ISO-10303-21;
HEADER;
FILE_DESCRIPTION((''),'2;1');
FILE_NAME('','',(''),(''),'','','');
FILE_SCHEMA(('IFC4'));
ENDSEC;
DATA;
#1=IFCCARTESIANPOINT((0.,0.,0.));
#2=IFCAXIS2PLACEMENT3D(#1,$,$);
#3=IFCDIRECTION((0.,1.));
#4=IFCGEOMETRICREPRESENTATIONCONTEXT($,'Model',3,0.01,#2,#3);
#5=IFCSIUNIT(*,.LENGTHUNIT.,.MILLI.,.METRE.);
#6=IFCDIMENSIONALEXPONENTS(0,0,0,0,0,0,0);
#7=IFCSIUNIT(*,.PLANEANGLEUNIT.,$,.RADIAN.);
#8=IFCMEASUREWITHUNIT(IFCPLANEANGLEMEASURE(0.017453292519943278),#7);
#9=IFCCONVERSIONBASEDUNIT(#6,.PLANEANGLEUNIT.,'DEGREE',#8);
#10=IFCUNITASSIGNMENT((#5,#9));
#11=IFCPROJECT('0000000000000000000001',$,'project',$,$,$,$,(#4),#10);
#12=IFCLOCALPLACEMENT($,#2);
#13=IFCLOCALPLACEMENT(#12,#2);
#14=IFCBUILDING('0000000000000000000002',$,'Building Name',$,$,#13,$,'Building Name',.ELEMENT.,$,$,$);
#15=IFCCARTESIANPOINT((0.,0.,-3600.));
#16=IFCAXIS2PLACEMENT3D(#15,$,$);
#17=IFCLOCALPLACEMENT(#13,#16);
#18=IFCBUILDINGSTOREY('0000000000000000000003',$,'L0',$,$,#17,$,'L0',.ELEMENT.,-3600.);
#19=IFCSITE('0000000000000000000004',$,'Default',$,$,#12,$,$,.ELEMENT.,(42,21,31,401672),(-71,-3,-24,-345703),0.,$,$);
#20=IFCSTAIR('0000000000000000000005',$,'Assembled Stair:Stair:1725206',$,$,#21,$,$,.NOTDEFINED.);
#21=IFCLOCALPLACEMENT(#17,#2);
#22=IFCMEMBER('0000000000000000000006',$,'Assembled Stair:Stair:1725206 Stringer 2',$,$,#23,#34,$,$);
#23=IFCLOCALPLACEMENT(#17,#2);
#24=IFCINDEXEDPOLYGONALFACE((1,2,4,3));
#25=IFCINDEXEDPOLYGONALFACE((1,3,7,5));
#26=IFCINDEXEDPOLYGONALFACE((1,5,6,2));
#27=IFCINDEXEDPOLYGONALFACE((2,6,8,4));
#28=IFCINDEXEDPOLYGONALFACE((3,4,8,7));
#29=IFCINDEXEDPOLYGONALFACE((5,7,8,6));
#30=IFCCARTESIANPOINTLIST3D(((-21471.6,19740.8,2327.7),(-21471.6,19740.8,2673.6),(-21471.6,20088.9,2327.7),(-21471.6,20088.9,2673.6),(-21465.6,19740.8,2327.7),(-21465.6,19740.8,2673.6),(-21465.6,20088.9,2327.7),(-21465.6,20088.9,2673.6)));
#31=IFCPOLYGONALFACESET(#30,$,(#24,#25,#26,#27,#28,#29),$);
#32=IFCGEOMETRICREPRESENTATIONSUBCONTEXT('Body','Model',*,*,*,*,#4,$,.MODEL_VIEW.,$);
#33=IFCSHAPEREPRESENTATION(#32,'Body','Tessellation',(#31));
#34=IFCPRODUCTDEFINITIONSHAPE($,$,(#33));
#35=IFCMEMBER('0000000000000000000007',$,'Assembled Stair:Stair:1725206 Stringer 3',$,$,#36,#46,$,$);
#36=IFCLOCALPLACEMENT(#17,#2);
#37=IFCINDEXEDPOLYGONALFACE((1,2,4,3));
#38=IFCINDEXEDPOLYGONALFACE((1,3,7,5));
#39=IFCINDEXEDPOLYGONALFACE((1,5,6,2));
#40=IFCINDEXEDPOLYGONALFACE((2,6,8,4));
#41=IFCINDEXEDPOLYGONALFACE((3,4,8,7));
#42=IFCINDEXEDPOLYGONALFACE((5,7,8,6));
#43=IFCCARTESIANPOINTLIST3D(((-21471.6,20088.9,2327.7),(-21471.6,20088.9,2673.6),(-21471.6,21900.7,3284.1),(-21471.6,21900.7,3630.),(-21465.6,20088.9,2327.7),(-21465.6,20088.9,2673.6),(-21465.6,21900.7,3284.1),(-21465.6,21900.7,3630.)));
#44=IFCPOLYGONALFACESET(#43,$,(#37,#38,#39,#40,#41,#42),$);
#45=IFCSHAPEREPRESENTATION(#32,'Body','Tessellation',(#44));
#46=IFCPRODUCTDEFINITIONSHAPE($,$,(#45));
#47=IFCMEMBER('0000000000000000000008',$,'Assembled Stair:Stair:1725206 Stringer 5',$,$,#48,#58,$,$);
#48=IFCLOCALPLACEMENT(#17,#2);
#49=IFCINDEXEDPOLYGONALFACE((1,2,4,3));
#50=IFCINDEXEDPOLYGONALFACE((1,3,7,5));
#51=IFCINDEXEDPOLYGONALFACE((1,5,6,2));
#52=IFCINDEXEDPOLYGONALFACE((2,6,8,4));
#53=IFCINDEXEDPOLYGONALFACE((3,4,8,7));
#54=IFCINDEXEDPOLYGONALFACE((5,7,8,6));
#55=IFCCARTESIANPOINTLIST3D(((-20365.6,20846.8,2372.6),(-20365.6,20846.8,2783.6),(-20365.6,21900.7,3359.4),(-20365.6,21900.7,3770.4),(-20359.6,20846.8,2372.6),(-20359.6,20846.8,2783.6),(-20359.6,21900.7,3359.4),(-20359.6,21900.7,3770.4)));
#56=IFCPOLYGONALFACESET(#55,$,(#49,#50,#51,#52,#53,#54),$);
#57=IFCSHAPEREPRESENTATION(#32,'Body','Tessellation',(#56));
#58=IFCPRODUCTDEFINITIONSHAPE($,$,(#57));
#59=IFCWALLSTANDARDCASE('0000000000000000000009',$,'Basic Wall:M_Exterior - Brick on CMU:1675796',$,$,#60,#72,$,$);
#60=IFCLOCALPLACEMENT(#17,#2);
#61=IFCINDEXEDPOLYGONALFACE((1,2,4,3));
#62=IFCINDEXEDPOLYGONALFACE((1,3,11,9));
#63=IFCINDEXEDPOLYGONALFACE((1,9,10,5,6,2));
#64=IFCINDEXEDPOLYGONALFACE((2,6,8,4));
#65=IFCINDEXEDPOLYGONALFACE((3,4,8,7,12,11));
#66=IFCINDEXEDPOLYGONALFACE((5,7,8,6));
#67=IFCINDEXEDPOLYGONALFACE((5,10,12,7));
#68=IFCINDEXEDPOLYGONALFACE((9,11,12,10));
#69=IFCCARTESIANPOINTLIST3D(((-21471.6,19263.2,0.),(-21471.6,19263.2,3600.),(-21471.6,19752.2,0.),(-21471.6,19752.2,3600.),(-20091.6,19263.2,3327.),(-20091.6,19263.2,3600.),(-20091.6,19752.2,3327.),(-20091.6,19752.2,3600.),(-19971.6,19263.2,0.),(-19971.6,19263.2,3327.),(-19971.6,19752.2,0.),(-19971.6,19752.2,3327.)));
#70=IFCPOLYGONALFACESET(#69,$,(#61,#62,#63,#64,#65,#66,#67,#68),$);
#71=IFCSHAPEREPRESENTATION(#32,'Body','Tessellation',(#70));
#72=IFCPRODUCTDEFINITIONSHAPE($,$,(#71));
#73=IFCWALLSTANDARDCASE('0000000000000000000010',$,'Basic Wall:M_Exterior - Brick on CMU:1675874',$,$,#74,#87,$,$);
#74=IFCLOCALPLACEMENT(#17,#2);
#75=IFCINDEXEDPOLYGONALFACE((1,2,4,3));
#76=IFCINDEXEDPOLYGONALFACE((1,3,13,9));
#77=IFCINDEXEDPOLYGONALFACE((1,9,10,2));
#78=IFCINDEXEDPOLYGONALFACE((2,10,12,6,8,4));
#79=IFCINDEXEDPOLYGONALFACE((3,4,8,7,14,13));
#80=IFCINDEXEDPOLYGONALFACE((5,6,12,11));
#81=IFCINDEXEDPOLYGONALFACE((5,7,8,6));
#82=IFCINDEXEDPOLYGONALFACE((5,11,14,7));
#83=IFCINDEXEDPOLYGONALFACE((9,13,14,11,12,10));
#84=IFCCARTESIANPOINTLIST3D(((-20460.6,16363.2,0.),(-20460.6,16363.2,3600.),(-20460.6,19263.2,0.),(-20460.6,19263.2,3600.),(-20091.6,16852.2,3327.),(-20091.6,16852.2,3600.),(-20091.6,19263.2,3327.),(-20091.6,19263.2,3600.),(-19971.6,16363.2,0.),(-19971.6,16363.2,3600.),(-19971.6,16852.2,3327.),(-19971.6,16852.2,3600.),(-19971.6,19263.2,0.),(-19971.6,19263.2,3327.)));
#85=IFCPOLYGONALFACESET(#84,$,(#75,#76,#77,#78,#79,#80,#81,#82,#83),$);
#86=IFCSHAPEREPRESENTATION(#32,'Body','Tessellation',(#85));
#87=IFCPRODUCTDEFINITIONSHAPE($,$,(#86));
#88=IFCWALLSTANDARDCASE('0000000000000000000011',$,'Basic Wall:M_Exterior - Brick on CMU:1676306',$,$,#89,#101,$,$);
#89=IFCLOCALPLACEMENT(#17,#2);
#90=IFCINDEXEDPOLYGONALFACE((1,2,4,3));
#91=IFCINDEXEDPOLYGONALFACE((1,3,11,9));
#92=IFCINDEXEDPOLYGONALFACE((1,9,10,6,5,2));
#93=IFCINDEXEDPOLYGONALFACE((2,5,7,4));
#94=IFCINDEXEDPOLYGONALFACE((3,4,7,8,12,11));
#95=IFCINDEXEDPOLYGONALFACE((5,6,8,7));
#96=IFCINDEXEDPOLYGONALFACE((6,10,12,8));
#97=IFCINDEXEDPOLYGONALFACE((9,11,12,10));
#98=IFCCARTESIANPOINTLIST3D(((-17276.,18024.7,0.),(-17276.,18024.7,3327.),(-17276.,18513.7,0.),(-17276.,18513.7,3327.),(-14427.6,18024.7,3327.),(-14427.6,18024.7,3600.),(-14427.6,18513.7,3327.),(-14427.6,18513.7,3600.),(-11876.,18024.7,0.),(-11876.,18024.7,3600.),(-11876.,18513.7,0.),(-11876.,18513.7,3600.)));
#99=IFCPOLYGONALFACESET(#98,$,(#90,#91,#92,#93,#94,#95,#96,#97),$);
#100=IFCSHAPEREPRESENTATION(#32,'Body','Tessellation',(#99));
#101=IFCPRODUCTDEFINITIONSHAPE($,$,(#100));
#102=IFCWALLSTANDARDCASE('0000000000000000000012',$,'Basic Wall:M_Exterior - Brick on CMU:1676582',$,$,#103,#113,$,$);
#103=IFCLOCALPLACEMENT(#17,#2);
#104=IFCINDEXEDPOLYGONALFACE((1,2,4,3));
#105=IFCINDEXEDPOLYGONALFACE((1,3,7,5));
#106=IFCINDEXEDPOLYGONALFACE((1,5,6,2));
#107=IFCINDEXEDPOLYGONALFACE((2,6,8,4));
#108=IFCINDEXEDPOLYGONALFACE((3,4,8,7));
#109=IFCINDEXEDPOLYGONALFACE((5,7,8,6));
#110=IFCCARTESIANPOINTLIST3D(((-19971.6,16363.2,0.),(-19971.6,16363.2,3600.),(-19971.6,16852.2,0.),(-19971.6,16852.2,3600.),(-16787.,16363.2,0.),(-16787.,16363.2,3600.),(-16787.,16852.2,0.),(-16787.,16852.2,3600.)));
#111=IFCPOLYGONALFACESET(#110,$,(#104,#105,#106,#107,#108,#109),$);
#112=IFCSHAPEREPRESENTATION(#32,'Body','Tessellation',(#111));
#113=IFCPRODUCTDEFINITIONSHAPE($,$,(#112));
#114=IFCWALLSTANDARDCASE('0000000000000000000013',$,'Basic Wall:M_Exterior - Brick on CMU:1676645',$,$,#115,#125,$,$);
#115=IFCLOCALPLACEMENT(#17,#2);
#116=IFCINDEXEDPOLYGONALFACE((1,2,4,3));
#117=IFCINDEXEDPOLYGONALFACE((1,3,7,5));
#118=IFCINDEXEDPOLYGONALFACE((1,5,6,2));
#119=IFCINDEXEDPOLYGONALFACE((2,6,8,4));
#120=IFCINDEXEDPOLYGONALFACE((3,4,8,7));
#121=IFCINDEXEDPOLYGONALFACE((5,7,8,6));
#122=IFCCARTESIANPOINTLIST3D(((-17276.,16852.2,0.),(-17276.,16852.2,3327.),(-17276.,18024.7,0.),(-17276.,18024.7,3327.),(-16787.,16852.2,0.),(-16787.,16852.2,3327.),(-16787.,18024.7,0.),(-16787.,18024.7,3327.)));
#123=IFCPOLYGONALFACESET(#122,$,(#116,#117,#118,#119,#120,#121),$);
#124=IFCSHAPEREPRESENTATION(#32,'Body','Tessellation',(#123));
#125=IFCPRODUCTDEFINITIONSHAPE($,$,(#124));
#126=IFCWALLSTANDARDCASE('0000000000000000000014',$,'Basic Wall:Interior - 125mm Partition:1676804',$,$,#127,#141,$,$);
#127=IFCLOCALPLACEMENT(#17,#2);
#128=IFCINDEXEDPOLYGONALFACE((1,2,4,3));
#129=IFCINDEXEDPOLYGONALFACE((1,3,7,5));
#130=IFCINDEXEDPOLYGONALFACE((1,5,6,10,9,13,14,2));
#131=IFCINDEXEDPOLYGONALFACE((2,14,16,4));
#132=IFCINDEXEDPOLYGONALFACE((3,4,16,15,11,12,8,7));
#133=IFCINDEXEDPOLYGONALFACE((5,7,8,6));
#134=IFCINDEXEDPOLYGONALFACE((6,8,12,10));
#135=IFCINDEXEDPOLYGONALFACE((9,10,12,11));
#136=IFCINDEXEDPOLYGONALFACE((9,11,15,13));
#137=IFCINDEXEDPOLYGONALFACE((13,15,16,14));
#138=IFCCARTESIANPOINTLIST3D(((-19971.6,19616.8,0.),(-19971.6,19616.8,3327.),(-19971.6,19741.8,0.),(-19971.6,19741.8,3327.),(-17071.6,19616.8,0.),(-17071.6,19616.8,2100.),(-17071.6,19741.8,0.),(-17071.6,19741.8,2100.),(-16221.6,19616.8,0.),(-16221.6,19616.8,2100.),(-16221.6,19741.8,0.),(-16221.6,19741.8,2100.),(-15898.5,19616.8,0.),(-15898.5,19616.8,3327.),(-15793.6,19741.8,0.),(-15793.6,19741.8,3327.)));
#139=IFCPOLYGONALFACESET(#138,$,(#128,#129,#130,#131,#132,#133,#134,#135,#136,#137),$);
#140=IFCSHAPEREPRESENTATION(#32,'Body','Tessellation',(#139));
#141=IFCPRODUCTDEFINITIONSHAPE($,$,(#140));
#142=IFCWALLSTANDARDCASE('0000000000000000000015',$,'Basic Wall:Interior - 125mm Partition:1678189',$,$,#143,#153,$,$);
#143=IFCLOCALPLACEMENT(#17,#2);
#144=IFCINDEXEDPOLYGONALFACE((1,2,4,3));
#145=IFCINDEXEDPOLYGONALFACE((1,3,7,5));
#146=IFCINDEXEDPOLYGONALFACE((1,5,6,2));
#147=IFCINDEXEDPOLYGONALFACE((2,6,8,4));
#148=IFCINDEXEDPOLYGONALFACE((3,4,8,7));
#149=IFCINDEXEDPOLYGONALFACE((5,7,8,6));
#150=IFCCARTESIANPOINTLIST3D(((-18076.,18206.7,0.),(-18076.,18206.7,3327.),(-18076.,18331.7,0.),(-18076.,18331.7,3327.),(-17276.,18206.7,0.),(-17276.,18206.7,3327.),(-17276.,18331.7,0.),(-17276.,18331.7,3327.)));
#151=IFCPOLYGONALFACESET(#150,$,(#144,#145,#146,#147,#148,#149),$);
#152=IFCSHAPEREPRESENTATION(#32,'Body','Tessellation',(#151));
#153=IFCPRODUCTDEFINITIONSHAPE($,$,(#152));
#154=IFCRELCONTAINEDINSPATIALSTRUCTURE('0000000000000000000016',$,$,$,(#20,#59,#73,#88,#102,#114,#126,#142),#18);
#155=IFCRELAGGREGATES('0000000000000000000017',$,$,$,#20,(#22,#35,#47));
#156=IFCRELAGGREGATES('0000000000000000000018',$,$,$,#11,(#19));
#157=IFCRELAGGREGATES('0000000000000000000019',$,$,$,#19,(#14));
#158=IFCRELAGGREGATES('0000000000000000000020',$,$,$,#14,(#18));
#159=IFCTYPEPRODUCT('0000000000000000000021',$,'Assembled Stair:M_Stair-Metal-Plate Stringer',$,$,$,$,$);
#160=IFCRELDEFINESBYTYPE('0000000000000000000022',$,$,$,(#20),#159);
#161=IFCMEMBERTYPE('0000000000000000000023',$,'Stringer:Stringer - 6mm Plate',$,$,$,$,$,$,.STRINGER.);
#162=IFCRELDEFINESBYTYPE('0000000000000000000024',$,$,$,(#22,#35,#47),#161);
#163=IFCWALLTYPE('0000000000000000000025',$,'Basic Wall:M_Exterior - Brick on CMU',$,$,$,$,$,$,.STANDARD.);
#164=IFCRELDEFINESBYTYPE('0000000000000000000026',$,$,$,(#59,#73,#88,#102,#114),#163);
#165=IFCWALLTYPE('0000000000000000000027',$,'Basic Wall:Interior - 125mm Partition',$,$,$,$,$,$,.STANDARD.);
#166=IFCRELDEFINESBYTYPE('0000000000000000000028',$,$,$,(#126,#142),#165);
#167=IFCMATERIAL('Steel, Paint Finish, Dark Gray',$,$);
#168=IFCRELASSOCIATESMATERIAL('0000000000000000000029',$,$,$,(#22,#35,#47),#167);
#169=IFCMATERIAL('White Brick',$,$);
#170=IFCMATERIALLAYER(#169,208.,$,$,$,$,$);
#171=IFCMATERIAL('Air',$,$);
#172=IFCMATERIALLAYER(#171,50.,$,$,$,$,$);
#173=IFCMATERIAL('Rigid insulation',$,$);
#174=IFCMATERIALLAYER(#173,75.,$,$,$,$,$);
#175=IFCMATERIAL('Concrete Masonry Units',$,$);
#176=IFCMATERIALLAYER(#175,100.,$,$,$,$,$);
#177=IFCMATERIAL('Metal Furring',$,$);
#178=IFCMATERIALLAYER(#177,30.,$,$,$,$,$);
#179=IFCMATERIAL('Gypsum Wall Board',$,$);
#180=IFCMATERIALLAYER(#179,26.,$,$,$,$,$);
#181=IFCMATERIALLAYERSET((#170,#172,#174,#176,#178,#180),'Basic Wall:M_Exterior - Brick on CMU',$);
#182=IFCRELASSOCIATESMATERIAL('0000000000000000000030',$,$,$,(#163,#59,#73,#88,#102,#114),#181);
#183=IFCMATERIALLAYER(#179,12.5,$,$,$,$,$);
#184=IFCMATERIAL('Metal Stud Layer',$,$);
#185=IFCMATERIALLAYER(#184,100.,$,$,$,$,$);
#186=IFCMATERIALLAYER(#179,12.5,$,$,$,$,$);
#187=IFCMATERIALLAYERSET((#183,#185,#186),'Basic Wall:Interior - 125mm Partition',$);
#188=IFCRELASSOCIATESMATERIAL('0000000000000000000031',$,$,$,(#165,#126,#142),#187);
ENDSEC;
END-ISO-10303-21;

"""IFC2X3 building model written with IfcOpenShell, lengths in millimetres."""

from ifc_helpers import new_model, entity, si_unit, converted_unit, direction, frame, frame_2d, origin, place, context, subcontext, project, spatial, polyline, rectangle, outline, extrude, clip, bounded_halfspace, material, layer, layer_set, layer_usage, type_object, element, aggregate, save


model = new_model("IFC2X3")

# Units and contexts
model_context = context("Model", 3, precision=0.01, world=origin(), true_north=direction((0.0, 1.0)))
body_context = subcontext(model_context, "Body", "Model", "MODEL_VIEW")
ifc_project = project(units=[si_unit("LENGTHUNIT", "METRE", prefix="MILLI"), converted_unit("PLANEANGLEUNIT", "DEGREE", entity("IfcPlaneAngleMeasure", 0.017453292519943278), si_unit("PLANEANGLEUNIT", "RADIAN"), dimensions=[0, 0, 0, 0, 0, 0, 0])], contexts=[model_context])

# Site, building, storey
site_placement = place(None, origin())
site = spatial("IfcSite", under=ifc_project, at=site_placement, Name="Default", CompositionType="ELEMENT", RefLatitude=(42, 21, 31, 401672), RefLongitude=(-71, -3, -24, -345703), RefElevation=0.0)
building_placement = place(site_placement, origin())
building = spatial("IfcBuilding", under=site, at=building_placement, Name="Building Name", LongName="Building Name", CompositionType="ELEMENT")
storey_placement = place(building_placement, frame((0.0, 0.0, -3600.0)))
storey = spatial("IfcBuildingStorey", under=building, at=storey_placement, Name="L0", LongName="L0", CompositionType="ELEMENT", Elevation=-3600.0)

# Stair, members
type_product = type_object("IfcTypeProduct", Name="Assembled Stair:M_Stair-Metal-Plate Stringer")
stair_placement = place(storey_placement, origin())
stair = element("IfcStair", 1, at=stair_placement, inside=storey, type_object=type_product, Name="Assembled Stair:Stair:1725206", ShapeType="NOTDEFINED")
ifc_material_1 = material(Name="Steel, Paint Finish, Dark Gray")
member_type = type_object("IfcMemberType", Name="Stringer:Stringer - 6mm Plate", PredefinedType="STRINGER")
member_1_placement = place(stair_placement, origin())
member_1 = element("IfcMember", 2, at=member_1_placement, type_object=member_type, material=ifc_material_1, Name="Assembled Stair:Stair:1725206 Stringer 2", context=body_context, shape_type="SweptSolid", body=[
    extrude(rectangle(XDim=348.1, YDim=6.0, at=frame_2d((0.0, 0.0), x_axis=(1.0, 0.0))), frame((-21468.6, 19914.8, 2327.7), z_axis=(0.0, 0.0, 1.0), x_axis=(0.0, 1.0, 0.0)), (0.0, 0.0, 1.0), 345.9),
])
member_2_placement = place(stair_placement, origin())
member_2 = element("IfcMember", 3, at=member_2_placement, type_object=member_type, material=ifc_material_1, Name="Assembled Stair:Stair:1725206 Stringer 3", context=body_context, shape_type="SweptSolid", body=[
    extrude(outline(polyline([(-1105.1, -153.0), (943.6, -153.0), (1105.1, 153.0), (-943.6, 153.0), (-1105.1, -153.0)])), frame((-21471.6, 20994.8, 2978.8), z_axis=(1.0, 0.0, 0.0), x_axis=(0.0, 0.884346, 0.466832)), (0.0, 0.0, 1.0), 6.0),
])
member_3_placement = place(stair_placement, origin())
member_3 = element("IfcMember", 4, at=member_3_placement, type_object=member_type, material=ifc_material_1, Name="Assembled Stair:Stair:1725206 Stringer 5", context=body_context, shape_type="SweptSolid", body=[
    extrude(outline(polyline([(-862.4, -150.0), (581.5, -150.0), (862.4, 150.0), (-581.5, 150.0), (-862.4, -150.0)])), frame((-20365.6, 21373.7, 3071.5), z_axis=(1.0, 0.0, 0.0), x_axis=(0.0, 0.729944, 0.683507)), (0.0, 0.0, 1.0), 6.0),
])
aggregate(stair, [member_1, member_2, member_3])

# Walls
ifc_material_2 = material(Name="White Brick")
ifc_layer_1 = layer(ifc_material_2, 208.0)
ifc_material_3 = material(Name="Air")
ifc_layer_2 = layer(ifc_material_3, 50.0)
ifc_material_4 = material(Name="Rigid insulation")
ifc_layer_3 = layer(ifc_material_4, 75.0)
ifc_material_5 = material(Name="Concrete Masonry Units")
ifc_layer_4 = layer(ifc_material_5, 100.0)
ifc_material_6 = material(Name="Metal Furring")
ifc_layer_5 = layer(ifc_material_6, 30.0)
ifc_material_7 = material(Name="Gypsum Wall Board")
ifc_layer_6 = layer(ifc_material_7, 26.0)
ifc_layer_set_1 = layer_set([ifc_layer_1, ifc_layer_2, ifc_layer_3, ifc_layer_4, ifc_layer_5, ifc_layer_6], Name="Basic Wall:M_Exterior - Brick on CMU")
ifc_layer_usage_1 = layer_usage(ifc_layer_set_1, "AXIS2", "NEGATIVE", 244.5)
wall_type_1 = type_object("IfcWallType", Name="Basic Wall:M_Exterior - Brick on CMU", PredefinedType="STANDARD", material=ifc_layer_set_1)
wall_1_placement = place(storey_placement, frame((-21471.6, 19507.7, 0.0)))
element("IfcWallStandardCase", 5, at=wall_1_placement, inside=storey, type_object=wall_type_1, material=ifc_layer_usage_1, Name="Basic Wall:M_Exterior - Brick on CMU:1675796", context=body_context, shape_type="Clipping", body=[
    clip(extrude(rectangle(XDim=1500.0, YDim=489.0, at=frame_2d((750.0, 0.0), x_axis=(-1.0, 0.0))), origin(), (0.0, 0.0, 1.0), 3600.0), bounded_halfspace(frame((1380.0, -244.5, 3327.0), z_axis=(0.0, 0.0, -1.0), x_axis=(0.0, 1.0, 0.0)), True, frame((1380.0, -244.5, 3327.0)), polyline([(0.0, 0.0), (120.0, 0.0), (120.0, 353.6), (120.0, 478.6), (120.0, 489.0), (0.0, 489.0), (0.0, 0.0)]))),
])
ifc_layer_usage_2 = layer_usage(ifc_layer_set_1, "AXIS2", "NEGATIVE", 244.5)
wall_2_placement = place(storey_placement, frame((-20216.1, 19263.2, 0.0), z_axis=(0.0, 0.0, 1.0), x_axis=(0.0, -1.0, 0.0)))
element("IfcWallStandardCase", 6, at=wall_2_placement, inside=storey, type_object=wall_type_1, material=ifc_layer_usage_2, Name="Basic Wall:M_Exterior - Brick on CMU:1675874", context=body_context, shape_type="Clipping", body=[
    clip(extrude(rectangle(XDim=2900.0, YDim=489.0, at=frame_2d((1450.0, 0.0), x_axis=(-1.0, 0.0))), origin(), (0.0, 0.0, 1.0), 3600.0), bounded_halfspace(frame((2411.0, 124.5, 3327.0), z_axis=(0.0, 0.0, -1.0), x_axis=(-1.0, 0.0, 0.0)), True, frame((2411.0, 124.5, 3327.0)), polyline([(0.0, 0.0), (0.0, 120.0), (-2411.0, 120.0), (-2411.0, 0.0), (0.0, 0.0)]))),
])
ifc_layer_usage_3 = layer_usage(ifc_layer_set_1, "AXIS2", "NEGATIVE", 244.5)
wall_3_placement = place(storey_placement, frame((-11876.0, 18269.2, 0.0), z_axis=(0.0, 0.0, 1.0), x_axis=(-1.0, 0.0, 0.0)))
element("IfcWallStandardCase", 7, at=wall_3_placement, inside=storey, type_object=wall_type_1, material=ifc_layer_usage_3, Name="Basic Wall:M_Exterior - Brick on CMU:1676306", context=body_context, shape_type="Clipping", body=[
    clip(extrude(rectangle(XDim=5400.0, YDim=489.0, at=frame_2d((2700.0, 0.0), x_axis=(-1.0, 0.0))), origin(), (0.0, 0.0, 1.0), 3600.0), bounded_halfspace(frame((2551.6, -244.5, 3327.0), z_axis=(0.0, 0.0, -1.0), x_axis=(0.0, -1.0, 0.0)), True, frame((2551.6, -244.5, 3327.0)), polyline([(0.0, 0.0), (1644.3, 0.0), (1769.3, 0.0), (2848.4, 0.0), (2848.4, 182.0), (2848.4, 307.0), (2848.4, 489.0), (2359.4, 489.0), (0.0, 489.0), (0.0, 0.0)]))),
])
ifc_layer_usage_4 = layer_usage(ifc_layer_set_1, "AXIS2", "NEGATIVE", 244.5)
wall_4_placement = place(storey_placement, frame((-19971.6, 16607.7, 0.0)))
element("IfcWallStandardCase", 8, at=wall_4_placement, inside=storey, type_object=wall_type_1, material=ifc_layer_usage_4, Name="Basic Wall:M_Exterior - Brick on CMU:1676582", context=body_context, shape_type="SweptSolid", body=[
    extrude(rectangle(XDim=3184.6, YDim=489.0, at=frame_2d((1592.3, 0.0), x_axis=(-1.0, 0.0))), origin(), (0.0, 0.0, 1.0), 3600.0),
])
ifc_layer_usage_5 = layer_usage(ifc_layer_set_1, "AXIS2", "NEGATIVE", 244.5)
wall_5_placement = place(storey_placement, frame((-17031.5, 16852.2, 0.0), z_axis=(0.0, 0.0, 1.0), x_axis=(0.0, 1.0, 0.0)))
element("IfcWallStandardCase", 9, at=wall_5_placement, inside=storey, type_object=wall_type_1, material=ifc_layer_usage_5, Name="Basic Wall:M_Exterior - Brick on CMU:1676645", context=body_context, shape_type="Clipping", body=[
    clip(extrude(rectangle(XDim=1172.5, YDim=489.0, at=frame_2d((586.3, 0.0), x_axis=(-1.0, 0.0))), origin(), (0.0, 0.0, 1.0), 3327.0), bounded_halfspace(frame((0.0, -244.5, 3327.0), z_axis=(0.0, 0.0, -1.0), x_axis=(1.0, 0.0, 0.0)), True, frame((0.0, -244.5, 3327.0)), polyline([(0.0, 0.0), (1172.5, 0.0), (1172.5, 489.0), (562.5, 489.0), (437.5, 489.0), (0.0, 489.0), (0.0, 0.0)]))),
])

# Wall, openings
ifc_layer_7 = layer(ifc_material_7, 12.5)
ifc_material_8 = material(Name="Metal Stud Layer")
ifc_layer_8 = layer(ifc_material_8, 100.0)
ifc_layer_9 = layer(ifc_material_7, 12.5)
ifc_layer_set_2 = layer_set([ifc_layer_7, ifc_layer_8, ifc_layer_9], Name="Basic Wall:Interior - 125mm Partition")
ifc_layer_usage_6 = layer_usage(ifc_layer_set_2, "AXIS2", "NEGATIVE", 62.5)
wall_type_2 = type_object("IfcWallType", Name="Basic Wall:Interior - 125mm Partition", PredefinedType="STANDARD", material=ifc_layer_set_2)
wall_6_placement = place(storey_placement, frame((-19971.6, 19679.3, 0.0)))
wall_6 = element("IfcWallStandardCase", 10, at=wall_6_placement, inside=storey, type_object=wall_type_2, material=ifc_layer_usage_6, Name="Basic Wall:Interior - 125mm Partition:1676804", context=body_context, shape_type="Clipping", body=[
    clip(extrude(outline(polyline([(0.0, -62.5), (3774.7, -62.5), (3899.7, -62.5), (4073.1, -62.5), (4178.0, 62.5), (4014.8, 62.5), (0.0, 62.5), (0.0, -62.5)])), origin(), (0.0, 0.0, 1.0), 3327.0), bounded_halfspace(frame((0.0, -62.5, 3327.0), z_axis=(0.0, 0.0, -1.0), x_axis=(0.0, 1.0, 0.0)), True, frame((0.0, -62.5, 3327.0)), polyline([(0.0, 0.0), (3774.7, 0.0), (3899.7, 0.0), (4073.1, 0.0), (4178.0, 125.0), (4014.8, 125.0), (0.0, 125.0), (0.0, 0.0)]))),
])
opening_1_placement = place(wall_6_placement, origin())
element("IfcOpeningElement", 11, at=opening_1_placement, cuts=wall_6, ObjectType="Opening", context=body_context, shape_type="SweptSolid", body=[
    extrude(rectangle(XDim=2100.0, YDim=125.0, at=frame_2d((0.0, 0.0), x_axis=(0.0, 1.0))), frame((4131.6, 104.4, 1050.0), z_axis=(0.642788, 0.766044, 0.0), x_axis=(0.766044, -0.642788, 0.0)), (0.0, 0.0, 1.0), 850.0),
])
opening_2_placement = place(wall_6_placement, frame((3750.0, 62.5, 0.0)))
element("IfcOpeningElement", 12, at=opening_2_placement, cuts=wall_6, ObjectType="Opening", context=body_context, shape_type="SweptSolid", body=[
    extrude(rectangle(XDim=2100.0, YDim=850.0, at=frame_2d((1050.0, 425.0), x_axis=(1.0, 0.0))), frame((0.0, 0.0, 0.0), z_axis=(0.0, -1.0, 0.0), x_axis=(0.0, 0.0, 1.0)), (0.0, 0.0, 1.0), 125.0),
])

# Wall
ifc_layer_usage_7 = layer_usage(ifc_layer_set_2, "AXIS2", "NEGATIVE", 62.5)
wall_7_placement = place(storey_placement, frame((-17276.0, 18269.2, 0.0), z_axis=(0.0, 0.0, 1.0), x_axis=(-1.0, 0.0, 0.0)))
element("IfcWallStandardCase", 13, at=wall_7_placement, inside=storey, type_object=wall_type_2, material=ifc_layer_usage_7, Name="Basic Wall:Interior - 125mm Partition:1678189", context=body_context, shape_type="SweptSolid", body=[
    extrude(rectangle(XDim=125.0, YDim=800.0, at=frame_2d((0.0, 0.0), x_axis=(1.0, 0.0))), frame((400.0, 0.0, 0.0), z_axis=(0.0, 0.0, 1.0), x_axis=(0.0, 1.0, 0.0)), (0.0, 0.0, 1.0), 3327.0),
])

save(model, "model.ifc")
